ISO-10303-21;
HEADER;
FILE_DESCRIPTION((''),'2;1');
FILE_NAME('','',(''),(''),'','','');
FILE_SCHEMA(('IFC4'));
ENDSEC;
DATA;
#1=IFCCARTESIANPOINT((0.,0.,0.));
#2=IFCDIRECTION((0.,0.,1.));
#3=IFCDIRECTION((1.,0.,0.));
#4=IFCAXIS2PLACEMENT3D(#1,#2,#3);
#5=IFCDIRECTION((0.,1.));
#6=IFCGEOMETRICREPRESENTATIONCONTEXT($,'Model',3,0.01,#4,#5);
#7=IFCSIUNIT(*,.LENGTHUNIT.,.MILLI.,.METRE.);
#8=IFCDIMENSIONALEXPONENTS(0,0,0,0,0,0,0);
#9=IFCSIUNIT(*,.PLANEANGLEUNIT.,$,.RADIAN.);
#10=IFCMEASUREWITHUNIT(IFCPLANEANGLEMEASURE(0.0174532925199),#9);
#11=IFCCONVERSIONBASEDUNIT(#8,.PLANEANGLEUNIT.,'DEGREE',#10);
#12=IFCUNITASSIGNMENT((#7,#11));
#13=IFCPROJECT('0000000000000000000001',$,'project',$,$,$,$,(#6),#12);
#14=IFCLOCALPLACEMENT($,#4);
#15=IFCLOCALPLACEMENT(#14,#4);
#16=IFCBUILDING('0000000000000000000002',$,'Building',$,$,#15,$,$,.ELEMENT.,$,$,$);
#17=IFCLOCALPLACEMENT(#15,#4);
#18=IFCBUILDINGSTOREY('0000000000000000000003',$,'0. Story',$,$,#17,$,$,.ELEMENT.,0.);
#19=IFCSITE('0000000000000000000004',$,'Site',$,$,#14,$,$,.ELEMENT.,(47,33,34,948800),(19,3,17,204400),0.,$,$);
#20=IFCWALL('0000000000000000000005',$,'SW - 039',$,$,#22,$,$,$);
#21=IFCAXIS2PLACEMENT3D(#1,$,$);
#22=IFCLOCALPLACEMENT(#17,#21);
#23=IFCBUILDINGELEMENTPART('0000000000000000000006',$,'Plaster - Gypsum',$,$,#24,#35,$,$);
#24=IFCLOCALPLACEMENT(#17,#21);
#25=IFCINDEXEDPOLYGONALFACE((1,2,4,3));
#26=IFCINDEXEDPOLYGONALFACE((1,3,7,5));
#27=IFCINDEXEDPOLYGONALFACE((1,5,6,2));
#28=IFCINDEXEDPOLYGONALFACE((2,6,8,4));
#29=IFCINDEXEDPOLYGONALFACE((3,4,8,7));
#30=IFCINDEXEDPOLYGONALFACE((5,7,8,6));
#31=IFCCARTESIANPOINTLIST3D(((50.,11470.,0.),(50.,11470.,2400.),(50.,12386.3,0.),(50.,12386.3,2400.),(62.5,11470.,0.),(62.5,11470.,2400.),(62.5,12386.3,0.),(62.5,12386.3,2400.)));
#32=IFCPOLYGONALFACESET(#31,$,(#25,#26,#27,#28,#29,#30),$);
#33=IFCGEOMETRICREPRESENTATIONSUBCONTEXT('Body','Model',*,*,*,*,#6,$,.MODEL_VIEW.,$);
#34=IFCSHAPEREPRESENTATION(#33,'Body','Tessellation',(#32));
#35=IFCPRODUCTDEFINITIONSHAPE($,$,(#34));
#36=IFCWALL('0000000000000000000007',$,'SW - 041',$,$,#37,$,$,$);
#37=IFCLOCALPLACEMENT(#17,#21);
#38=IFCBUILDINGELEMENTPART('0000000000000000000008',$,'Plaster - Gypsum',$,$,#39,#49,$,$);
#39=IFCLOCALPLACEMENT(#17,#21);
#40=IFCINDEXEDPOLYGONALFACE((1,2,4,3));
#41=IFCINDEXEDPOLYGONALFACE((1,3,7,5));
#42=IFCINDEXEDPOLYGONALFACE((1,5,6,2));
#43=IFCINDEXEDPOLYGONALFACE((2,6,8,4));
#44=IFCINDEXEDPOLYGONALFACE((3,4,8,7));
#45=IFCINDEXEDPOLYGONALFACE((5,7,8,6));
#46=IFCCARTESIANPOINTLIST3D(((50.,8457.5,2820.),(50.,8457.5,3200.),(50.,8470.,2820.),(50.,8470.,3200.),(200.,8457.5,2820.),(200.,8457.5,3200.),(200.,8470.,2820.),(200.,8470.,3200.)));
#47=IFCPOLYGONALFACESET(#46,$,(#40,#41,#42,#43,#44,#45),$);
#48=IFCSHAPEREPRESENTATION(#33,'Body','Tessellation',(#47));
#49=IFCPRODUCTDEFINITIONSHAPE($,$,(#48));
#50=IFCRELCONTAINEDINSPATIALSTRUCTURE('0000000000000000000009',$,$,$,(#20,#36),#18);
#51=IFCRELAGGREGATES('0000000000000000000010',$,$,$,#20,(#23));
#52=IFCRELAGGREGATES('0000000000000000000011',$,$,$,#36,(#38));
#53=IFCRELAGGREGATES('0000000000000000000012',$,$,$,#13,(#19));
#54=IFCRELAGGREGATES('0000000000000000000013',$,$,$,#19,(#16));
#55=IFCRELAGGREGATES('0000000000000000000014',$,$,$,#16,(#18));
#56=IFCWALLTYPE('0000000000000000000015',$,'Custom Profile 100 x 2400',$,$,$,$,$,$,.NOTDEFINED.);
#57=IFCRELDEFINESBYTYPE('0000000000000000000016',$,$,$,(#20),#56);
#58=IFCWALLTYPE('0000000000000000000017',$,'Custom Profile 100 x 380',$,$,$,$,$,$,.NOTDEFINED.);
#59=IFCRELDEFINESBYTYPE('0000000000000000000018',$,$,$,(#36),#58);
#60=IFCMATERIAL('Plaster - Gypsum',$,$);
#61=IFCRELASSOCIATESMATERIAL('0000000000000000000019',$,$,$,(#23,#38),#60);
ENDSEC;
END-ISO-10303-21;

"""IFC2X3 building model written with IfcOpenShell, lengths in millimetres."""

from ifc_helpers import new_model, entity, si_unit, converted_unit, direction, frame, origin_with_axes, place, context, subcontext, project, spatial, polyline, outline, extrude, material, type_object, element, aggregate, save


model = new_model("IFC2X3")

# Units and contexts
model_context = context("Model", 3, precision=0.01, world=origin_with_axes(), true_north=direction((0.0, 1.0)))
body_context = subcontext(model_context, "Body", "Model", "MODEL_VIEW")
ifc_project = project(units=[si_unit("LENGTHUNIT", "METRE", prefix="MILLI"), converted_unit("PLANEANGLEUNIT", "DEGREE", entity("IfcPlaneAngleMeasure", 0.0174532925199), si_unit("PLANEANGLEUNIT", "RADIAN"), dimensions=[0, 0, 0, 0, 0, 0, 0])], contexts=[model_context])

# Site, building, storey
site_placement = place(None, origin_with_axes())
site = spatial("IfcSite", under=ifc_project, at=site_placement, Name="Site", CompositionType="ELEMENT", RefLatitude=(47, 33, 34, 948800), RefLongitude=(19, 3, 17, 204400), RefElevation=0.0)
building_placement = place(site_placement, origin_with_axes())
building = spatial("IfcBuilding", under=site, at=building_placement, Name="Building", CompositionType="ELEMENT")
storey_placement = place(building_placement, origin_with_axes())
storey = spatial("IfcBuildingStorey", under=building, at=storey_placement, Name="0. Story", CompositionType="ELEMENT", Elevation=0.0)

# Shared definitions
ifc_material_1 = material(Name="Plaster - Gypsum")

# Shared definitions
wall_type_1 = type_object("IfcWallType", Name="Custom Profile 100 x 2400", PredefinedType="NOTDEFINED")

# Walls, building element parts
wall_1_placement = place(storey_placement, frame((50.0, 11470.0, 0.0), z_axis=(0.0, 0.0, 1.0), x_axis=(0.0, 1.0, 0.0)))
wall_1 = element("IfcWall", 1, at=wall_1_placement, inside=storey, type_object=wall_type_1, Name="SW - 039")
building_element_part_1_placement = place(wall_1_placement, origin_with_axes())
building_element_part_1 = element("IfcBuildingElementPart", 2, at=building_element_part_1_placement, material=ifc_material_1, Name="Plaster - Gypsum", context=body_context, shape_type="SweptSolid", body=[
    extrude(outline(polyline([(-12.5, 2400.0), (-12.5, 0.0), (0.0, 0.0), (0.0, 2400.0), (-12.5, 2400.0)])), frame((0.0, 0.0, 0.0), z_axis=(1.0, 0.0, 0.0), x_axis=(0.0, 1.0, 0.0)), (0.0, 0.0, 1.0), 916.3),
])
aggregate(wall_1, [building_element_part_1])
wall_type_2 = type_object("IfcWallType", Name="Custom Profile 100 x 380", PredefinedType="NOTDEFINED")
wall_2_placement = place(storey_placement, frame((200.0, 8470.0, 2820.0), z_axis=(0.0, 0.0, 1.0), x_axis=(-1.0, 0.0, 0.0)))
wall_2 = element("IfcWall", 3, at=wall_2_placement, inside=storey, type_object=wall_type_2, Name="SW - 041")
building_element_part_2_placement = place(wall_2_placement, origin_with_axes())
building_element_part_2 = element("IfcBuildingElementPart", 4, at=building_element_part_2_placement, material=ifc_material_1, Name="Plaster - Gypsum", context=body_context, shape_type="SweptSolid", body=[
    extrude(outline(polyline([(-12.5, 380.0), (-12.5, 0.0), (0.0, 0.0), (0.0, 380.0), (-12.5, 380.0)])), frame((0.0, 0.0, 0.0), z_axis=(-1.0, 0.0, 0.0), x_axis=(0.0, -1.0, 0.0)), (0.0, 0.0, -1.0), 150.0),
])
aggregate(wall_2, [building_element_part_2])

save(model, "model.ifc")
